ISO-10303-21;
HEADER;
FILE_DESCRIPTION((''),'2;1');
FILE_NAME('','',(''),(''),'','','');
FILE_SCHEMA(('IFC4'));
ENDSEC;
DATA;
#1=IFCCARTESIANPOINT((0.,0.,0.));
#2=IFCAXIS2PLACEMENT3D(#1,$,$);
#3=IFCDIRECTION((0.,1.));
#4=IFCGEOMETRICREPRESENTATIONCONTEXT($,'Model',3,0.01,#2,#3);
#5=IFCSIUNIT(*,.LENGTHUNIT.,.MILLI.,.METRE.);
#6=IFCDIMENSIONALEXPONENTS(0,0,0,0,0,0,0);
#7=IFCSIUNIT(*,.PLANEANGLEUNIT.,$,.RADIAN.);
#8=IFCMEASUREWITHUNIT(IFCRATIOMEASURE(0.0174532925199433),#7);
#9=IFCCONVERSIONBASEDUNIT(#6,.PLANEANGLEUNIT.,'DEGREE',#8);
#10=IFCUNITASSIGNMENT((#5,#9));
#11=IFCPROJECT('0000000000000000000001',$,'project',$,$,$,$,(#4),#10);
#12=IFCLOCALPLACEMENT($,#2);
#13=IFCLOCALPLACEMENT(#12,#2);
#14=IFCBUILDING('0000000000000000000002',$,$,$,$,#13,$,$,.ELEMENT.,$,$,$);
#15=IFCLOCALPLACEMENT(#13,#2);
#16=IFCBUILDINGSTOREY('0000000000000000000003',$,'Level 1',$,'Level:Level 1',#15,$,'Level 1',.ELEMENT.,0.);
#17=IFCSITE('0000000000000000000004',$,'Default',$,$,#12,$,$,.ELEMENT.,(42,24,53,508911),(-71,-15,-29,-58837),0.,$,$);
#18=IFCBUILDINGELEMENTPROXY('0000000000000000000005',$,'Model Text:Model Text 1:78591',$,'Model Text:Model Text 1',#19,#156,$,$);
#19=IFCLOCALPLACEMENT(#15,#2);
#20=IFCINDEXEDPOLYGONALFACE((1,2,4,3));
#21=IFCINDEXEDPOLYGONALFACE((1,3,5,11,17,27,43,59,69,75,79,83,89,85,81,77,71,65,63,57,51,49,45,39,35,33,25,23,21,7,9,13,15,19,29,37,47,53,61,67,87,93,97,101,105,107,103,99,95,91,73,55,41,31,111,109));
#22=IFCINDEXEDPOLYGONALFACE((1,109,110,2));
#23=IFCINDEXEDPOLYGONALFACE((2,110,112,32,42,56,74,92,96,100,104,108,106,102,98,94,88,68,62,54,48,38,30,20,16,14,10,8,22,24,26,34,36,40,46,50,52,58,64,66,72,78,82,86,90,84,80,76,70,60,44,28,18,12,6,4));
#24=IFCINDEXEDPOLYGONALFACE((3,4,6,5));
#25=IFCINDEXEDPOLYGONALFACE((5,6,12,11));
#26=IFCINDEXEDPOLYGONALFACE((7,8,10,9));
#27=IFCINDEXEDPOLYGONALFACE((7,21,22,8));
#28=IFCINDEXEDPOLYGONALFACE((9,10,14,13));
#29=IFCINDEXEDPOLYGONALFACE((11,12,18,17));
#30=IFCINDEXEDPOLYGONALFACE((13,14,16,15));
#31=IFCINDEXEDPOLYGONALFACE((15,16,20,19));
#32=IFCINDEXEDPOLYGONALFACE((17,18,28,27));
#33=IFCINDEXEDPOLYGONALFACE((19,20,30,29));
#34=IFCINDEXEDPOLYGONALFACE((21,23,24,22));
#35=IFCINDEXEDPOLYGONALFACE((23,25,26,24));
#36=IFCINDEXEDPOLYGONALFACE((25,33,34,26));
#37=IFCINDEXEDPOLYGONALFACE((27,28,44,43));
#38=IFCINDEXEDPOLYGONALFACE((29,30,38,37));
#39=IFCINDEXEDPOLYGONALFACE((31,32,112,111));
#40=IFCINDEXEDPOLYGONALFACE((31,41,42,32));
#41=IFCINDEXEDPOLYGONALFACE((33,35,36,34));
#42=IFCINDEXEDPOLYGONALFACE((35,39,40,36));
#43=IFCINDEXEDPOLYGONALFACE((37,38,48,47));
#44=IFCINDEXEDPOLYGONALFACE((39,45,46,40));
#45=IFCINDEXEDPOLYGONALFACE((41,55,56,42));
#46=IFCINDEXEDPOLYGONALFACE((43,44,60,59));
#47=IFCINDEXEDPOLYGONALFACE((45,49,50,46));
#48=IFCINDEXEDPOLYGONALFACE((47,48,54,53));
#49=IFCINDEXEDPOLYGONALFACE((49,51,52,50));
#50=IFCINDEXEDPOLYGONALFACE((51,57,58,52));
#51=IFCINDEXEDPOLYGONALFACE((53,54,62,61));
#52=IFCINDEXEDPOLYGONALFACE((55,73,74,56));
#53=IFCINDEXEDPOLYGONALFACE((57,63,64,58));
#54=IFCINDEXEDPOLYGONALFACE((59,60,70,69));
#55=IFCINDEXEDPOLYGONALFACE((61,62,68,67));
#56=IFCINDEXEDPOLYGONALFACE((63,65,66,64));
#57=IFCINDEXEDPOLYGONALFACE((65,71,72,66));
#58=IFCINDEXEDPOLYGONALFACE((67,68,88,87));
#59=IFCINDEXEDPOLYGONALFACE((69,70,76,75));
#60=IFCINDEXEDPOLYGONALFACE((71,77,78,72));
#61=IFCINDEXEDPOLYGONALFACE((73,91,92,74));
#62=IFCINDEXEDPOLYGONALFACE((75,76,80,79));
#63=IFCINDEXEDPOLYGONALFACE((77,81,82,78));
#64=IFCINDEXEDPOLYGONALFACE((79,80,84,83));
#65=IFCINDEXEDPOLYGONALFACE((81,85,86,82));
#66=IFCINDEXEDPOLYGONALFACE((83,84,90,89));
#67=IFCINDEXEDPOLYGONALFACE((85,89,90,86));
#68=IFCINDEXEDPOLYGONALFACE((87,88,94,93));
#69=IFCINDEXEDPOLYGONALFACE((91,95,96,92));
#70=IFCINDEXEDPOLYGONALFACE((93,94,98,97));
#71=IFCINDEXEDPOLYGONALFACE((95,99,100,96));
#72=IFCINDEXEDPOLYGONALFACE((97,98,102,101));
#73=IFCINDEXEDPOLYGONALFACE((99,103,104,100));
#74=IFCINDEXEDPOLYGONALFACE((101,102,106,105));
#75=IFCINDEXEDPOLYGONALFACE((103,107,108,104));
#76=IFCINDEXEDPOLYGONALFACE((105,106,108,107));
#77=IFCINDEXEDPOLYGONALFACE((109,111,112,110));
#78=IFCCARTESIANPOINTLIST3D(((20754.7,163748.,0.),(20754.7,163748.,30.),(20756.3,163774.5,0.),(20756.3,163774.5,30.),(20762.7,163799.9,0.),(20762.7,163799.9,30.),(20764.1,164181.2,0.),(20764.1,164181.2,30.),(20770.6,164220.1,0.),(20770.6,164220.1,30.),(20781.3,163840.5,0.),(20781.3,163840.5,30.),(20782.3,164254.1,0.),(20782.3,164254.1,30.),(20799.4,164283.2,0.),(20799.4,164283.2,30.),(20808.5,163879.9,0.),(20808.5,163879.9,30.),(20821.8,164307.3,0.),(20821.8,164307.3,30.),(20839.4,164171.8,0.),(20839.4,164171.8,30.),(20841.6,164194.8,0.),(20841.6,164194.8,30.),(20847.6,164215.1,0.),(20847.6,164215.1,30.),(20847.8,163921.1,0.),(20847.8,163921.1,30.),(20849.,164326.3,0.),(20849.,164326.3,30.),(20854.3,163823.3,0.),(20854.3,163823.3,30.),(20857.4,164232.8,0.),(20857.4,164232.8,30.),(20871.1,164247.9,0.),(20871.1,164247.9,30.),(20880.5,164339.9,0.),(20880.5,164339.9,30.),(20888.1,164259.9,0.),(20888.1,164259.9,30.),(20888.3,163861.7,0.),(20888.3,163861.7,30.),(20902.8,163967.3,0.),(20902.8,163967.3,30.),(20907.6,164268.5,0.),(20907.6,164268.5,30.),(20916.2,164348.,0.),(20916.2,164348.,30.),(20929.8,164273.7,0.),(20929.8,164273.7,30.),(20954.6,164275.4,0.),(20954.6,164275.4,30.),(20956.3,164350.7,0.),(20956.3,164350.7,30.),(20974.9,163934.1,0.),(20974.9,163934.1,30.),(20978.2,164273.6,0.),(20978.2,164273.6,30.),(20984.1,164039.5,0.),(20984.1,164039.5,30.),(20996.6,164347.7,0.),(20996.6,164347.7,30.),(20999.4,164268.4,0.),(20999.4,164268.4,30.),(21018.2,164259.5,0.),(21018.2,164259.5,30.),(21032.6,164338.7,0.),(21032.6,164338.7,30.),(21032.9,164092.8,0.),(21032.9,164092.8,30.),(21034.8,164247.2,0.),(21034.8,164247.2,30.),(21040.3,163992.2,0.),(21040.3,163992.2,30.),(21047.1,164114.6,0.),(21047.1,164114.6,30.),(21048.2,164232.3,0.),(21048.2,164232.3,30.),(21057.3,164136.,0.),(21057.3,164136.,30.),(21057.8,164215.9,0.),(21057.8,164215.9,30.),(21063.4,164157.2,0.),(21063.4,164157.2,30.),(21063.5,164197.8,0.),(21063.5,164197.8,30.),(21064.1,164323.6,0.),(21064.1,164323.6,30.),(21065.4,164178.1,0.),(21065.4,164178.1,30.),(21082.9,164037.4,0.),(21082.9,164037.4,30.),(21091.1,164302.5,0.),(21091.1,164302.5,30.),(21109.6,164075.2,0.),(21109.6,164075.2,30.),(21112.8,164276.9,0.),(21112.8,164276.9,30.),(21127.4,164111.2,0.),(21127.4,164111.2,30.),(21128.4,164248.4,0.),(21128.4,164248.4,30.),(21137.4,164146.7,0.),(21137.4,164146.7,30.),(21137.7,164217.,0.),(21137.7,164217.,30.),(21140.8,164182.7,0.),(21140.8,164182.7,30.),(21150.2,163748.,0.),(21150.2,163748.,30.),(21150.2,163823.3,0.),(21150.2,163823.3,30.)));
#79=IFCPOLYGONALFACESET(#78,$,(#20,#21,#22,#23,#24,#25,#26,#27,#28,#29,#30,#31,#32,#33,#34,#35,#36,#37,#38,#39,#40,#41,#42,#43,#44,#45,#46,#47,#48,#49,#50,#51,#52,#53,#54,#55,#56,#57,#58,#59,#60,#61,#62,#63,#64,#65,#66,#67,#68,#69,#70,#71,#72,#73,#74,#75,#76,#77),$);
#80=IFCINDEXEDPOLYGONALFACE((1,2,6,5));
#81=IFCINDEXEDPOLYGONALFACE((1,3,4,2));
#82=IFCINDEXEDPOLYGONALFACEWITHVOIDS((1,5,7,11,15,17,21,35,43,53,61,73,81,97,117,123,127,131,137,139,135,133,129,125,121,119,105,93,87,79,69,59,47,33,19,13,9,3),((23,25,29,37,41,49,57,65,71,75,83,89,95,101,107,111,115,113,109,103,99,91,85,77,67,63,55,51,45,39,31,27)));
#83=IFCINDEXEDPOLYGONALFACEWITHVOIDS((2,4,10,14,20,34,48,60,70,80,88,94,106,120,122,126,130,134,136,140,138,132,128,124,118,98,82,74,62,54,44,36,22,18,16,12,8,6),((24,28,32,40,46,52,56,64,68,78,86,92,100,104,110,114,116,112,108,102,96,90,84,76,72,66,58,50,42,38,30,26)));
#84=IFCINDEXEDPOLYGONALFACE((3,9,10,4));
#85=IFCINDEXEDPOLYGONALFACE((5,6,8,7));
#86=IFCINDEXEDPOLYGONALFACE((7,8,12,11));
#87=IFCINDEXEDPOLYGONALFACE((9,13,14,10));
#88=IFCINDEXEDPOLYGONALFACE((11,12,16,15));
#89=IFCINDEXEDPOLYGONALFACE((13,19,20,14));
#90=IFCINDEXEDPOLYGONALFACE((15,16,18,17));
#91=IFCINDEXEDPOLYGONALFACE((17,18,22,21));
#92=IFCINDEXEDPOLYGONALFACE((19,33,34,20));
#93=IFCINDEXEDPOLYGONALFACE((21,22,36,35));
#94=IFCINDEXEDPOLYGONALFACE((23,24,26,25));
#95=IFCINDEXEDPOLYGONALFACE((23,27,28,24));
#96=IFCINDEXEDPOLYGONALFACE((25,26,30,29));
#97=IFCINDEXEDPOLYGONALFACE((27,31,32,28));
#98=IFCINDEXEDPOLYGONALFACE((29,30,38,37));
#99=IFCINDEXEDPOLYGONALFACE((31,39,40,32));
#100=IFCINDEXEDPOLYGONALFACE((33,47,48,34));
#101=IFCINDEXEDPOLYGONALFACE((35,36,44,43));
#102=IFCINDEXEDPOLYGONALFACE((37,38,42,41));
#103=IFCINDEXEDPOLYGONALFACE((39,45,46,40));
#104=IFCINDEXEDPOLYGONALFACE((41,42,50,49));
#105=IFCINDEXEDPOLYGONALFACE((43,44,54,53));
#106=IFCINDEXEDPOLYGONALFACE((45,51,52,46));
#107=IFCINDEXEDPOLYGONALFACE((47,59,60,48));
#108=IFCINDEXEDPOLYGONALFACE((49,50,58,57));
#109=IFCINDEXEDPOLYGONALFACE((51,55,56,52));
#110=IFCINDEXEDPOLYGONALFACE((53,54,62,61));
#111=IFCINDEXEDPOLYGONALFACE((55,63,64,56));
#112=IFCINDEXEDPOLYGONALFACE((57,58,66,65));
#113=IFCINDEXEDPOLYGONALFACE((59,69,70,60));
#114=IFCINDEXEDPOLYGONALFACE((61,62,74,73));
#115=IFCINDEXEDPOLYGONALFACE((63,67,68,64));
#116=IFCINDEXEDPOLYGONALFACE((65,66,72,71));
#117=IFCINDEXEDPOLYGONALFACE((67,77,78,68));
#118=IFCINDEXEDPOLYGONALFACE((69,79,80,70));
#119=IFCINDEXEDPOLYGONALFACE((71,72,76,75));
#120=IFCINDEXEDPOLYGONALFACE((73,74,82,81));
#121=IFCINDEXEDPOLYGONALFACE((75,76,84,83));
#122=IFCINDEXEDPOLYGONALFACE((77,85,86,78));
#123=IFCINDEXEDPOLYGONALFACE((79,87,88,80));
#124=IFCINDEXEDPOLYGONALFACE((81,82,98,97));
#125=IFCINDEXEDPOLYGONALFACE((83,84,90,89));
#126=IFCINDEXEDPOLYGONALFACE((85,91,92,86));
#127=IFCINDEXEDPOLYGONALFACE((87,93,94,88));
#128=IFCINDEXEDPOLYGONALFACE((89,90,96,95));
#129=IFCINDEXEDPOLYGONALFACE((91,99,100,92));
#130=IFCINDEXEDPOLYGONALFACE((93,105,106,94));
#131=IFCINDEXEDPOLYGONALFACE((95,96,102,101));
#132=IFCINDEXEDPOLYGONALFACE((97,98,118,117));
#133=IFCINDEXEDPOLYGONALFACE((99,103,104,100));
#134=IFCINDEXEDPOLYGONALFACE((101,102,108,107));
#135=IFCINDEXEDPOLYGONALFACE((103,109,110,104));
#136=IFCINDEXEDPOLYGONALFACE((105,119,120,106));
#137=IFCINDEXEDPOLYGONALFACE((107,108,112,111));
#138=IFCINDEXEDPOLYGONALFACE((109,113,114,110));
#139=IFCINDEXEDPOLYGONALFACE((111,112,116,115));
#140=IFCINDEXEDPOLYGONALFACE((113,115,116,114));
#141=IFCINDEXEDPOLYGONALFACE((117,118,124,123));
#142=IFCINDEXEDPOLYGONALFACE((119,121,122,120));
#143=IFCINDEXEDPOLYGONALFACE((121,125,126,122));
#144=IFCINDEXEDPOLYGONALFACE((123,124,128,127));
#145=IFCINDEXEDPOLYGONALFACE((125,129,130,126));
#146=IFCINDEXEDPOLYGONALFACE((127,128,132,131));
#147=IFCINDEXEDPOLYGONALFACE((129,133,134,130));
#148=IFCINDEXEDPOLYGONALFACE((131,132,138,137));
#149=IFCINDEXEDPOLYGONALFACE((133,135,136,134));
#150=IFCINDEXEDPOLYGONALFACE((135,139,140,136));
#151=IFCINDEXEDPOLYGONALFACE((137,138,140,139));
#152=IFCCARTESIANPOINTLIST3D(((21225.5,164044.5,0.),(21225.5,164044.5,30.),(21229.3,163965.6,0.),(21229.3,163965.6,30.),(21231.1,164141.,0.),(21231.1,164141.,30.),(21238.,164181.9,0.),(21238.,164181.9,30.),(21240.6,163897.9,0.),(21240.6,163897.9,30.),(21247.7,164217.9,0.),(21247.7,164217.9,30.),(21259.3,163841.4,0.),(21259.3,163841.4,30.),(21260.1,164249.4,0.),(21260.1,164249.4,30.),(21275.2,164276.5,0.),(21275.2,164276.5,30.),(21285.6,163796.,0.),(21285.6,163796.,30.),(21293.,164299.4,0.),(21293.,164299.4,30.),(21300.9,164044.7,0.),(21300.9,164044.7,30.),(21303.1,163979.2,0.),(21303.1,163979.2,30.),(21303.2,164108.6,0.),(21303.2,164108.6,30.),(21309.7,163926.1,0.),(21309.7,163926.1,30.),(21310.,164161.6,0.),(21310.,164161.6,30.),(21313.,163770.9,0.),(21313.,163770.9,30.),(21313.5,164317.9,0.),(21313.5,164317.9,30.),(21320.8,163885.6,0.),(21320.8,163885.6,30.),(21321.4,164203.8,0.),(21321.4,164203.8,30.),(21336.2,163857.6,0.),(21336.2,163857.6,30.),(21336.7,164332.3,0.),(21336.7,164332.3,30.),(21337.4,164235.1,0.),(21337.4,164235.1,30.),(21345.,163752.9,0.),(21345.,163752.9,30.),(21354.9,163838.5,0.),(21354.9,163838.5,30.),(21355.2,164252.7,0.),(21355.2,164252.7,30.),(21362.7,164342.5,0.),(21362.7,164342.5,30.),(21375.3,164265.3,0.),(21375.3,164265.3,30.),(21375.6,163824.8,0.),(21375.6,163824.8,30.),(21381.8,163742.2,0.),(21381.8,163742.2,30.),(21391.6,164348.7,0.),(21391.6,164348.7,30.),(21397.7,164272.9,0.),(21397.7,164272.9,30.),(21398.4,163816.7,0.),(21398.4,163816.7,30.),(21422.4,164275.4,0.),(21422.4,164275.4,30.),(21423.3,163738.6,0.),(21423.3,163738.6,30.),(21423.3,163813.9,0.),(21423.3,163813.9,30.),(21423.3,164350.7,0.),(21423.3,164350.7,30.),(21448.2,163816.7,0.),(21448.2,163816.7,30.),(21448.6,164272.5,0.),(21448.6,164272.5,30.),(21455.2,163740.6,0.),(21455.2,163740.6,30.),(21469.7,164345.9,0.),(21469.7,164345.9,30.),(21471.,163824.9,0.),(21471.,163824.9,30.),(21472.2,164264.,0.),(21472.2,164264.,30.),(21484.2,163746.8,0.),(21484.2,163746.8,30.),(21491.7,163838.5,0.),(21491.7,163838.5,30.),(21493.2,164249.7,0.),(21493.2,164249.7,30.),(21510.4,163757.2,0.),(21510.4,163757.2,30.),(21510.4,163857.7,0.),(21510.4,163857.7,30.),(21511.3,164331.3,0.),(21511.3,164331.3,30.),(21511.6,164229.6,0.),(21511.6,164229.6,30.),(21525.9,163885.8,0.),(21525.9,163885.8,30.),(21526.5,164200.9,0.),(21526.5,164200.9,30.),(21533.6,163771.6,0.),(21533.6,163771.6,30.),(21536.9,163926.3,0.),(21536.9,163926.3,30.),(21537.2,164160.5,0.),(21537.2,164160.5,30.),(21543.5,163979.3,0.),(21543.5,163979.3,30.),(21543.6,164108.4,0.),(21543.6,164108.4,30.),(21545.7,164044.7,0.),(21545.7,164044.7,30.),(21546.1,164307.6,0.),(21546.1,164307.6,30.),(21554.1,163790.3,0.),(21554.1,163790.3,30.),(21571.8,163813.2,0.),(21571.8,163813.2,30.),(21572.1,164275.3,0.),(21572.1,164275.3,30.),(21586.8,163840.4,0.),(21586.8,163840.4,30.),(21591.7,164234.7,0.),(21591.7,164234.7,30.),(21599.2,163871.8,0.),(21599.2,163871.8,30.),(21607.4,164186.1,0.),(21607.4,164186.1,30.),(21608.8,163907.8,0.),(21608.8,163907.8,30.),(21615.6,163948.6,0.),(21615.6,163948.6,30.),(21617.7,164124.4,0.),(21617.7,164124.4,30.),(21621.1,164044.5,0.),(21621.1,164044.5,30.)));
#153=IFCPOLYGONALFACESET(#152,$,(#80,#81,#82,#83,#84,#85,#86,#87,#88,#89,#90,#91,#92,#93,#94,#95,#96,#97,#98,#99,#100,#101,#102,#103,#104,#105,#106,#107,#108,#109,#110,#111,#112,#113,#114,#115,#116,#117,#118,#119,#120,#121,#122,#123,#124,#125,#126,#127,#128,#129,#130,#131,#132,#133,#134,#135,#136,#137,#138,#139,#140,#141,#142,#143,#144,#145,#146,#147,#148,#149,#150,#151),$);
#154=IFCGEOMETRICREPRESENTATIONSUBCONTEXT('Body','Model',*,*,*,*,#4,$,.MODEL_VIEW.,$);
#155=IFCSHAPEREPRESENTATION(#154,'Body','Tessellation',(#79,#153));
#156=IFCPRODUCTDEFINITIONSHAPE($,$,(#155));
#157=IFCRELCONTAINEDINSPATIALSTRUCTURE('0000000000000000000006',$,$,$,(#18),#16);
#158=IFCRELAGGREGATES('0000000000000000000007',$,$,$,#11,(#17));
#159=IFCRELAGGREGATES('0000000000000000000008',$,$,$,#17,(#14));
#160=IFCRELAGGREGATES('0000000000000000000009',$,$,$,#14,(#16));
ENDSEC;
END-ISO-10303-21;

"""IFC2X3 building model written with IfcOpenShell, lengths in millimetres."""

from ifc_helpers import new_model, entity, si_unit, converted_unit, direction, frame, origin, place, context, subcontext, project, spatial, polyline, outline, extrude, element, save


model = new_model("IFC2X3")

# Units and contexts
model_context = context("Model", 3, precision=0.01, world=origin(), true_north=direction((0.0, 1.0)))
body_context = subcontext(model_context, "Body", "Model", "MODEL_VIEW")
ifc_project = project(units=[si_unit("LENGTHUNIT", "METRE", prefix="MILLI"), converted_unit("PLANEANGLEUNIT", "DEGREE", entity("IfcRatioMeasure", 0.0174532925199433), si_unit("PLANEANGLEUNIT", "RADIAN"), dimensions=[0, 0, 0, 0, 0, 0, 0])], contexts=[model_context])

# Site, building, storey
site_placement = place(None, origin())
site = spatial("IfcSite", under=ifc_project, at=site_placement, Name="Default", CompositionType="ELEMENT", RefLatitude=(42, 24, 53, 508911), RefLongitude=(-71, -15, -29, -58837), RefElevation=0.0)
building_placement = place(site_placement, origin())
building = spatial("IfcBuilding", under=site, at=building_placement, CompositionType="ELEMENT")
storey_placement = place(building_placement, origin())
storey = spatial("IfcBuildingStorey", under=building, at=storey_placement, Name="Level 1", ObjectType="Level:Level 1", LongName="Level 1", CompositionType="ELEMENT", Elevation=0.0)

# Building element proxy
proxy_1_placement = place(storey_placement, origin())
element("IfcBuildingElementProxy", 1, at=proxy_1_placement, inside=storey, Name="Model Text:Model Text 1:78591", ObjectType="Model Text:Model Text 1", context=body_context, shape_type="SweptSolid", body=[
    extrude(outline(polyline([(-190.2, -317.5), (-190.2, -392.8), (205.4, -392.8), (203.7, -366.3), (197.3, -340.9), (178.7, -300.3), (151.5, -260.9), (112.2, -219.7), (57.2, -173.6), (-24.1, -101.3), (-72.9, -48.0), (-87.1, -26.3), (-97.3, -4.8), (-103.4, 16.4), (-105.4, 37.3), (-103.5, 57.0), (-97.7, 75.0), (-88.2, 91.5), (-74.7, 106.4), (-58.2, 118.7), (-39.4, 127.5), (-18.2, 132.8), (5.4, 134.6), (30.2, 132.9), (52.4, 127.7), (72.0, 119.1), (88.9, 107.1), (102.6, 92.0), (112.5, 74.3), (118.5, 54.0), (120.6, 31.0), (196.0, 40.4), (189.5, 79.3), (177.7, 113.3), (160.6, 142.4), (138.2, 166.5), (111.0, 185.5), (79.5, 199.1), (43.8, 207.2), (3.8, 209.9), (-36.6, 206.9), (-72.5, 197.9), (-104.0, 182.8), (-131.1, 161.7), (-152.8, 136.1), (-168.3, 107.6), (-177.6, 76.2), (-180.8, 41.9), (-177.4, 5.8), (-167.4, -29.6), (-149.5, -65.6), (-122.8, -103.4), (-80.3, -148.6), (-14.9, -206.7), (71.8, -279.1), (105.8, -317.5), (-190.2, -317.5)])), frame((20960.0, 164140.8, 0.0), z_axis=(0.0, 0.0, -1.0), x_axis=(-1.0, 0.0, 0.0)), (0.0, 0.0, -1.0), 30.0),
    extrude(outline(polyline([(-10.6, -198.7), (68.3, -198.7), (136.5, -190.7), (193.9, -174.7), (240.5, -150.6), (266.9, -124.4), (286.3, -93.2), (298.8, -57.0), (304.3, -15.7), (303.8, 16.2), (299.0, 45.5), (289.9, 72.1), (276.6, 96.0), (258.9, 117.3), (236.9, 136.2), (210.4, 152.5), (179.6, 166.3), (144.1, 177.6), (103.7, 186.3), (8.2, 196.4), (-71.8, 196.7), (-134.0, 189.4), (-183.3, 176.1), (-224.7, 158.4), (-258.2, 133.9), (-283.5, 100.3), (-300.1, 59.5), (-307.1, 13.4), (-306.6, -18.4), (-301.8, -47.5), (-292.8, -74.0), (-279.6, -97.9), (-262.0, -119.2), (-240.0, -138.1), (-213.6, -154.5), (-182.8, -168.4), (-147.3, -179.8), (-106.7, -188.6), (-10.6, -198.7)]), holes=[polyline([(-7.2, -123.5), (-71.0, -118.2), (-123.6, -108.8), (-165.2, -95.4), (-195.7, -78.0), (-212.4, -59.4), (-224.1, -38.7), (-230.6, -15.9), (-231.9, 8.9), (-227.8, 35.0), (-218.1, 58.1), (-202.8, 78.4), (-182.0, 95.8), (-152.6, 109.4), (-111.7, 118.1), (-59.4, 122.0), (4.4, 121.1), (69.6, 115.8), (122.2, 106.7), (162.2, 93.7), (189.5, 77.0), (207.7, 57.4), (220.4, 36.0), (227.5, 12.8), (229.1, -12.1), (225.2, -36.8), (215.9, -59.2), (201.3, -79.3), (181.4, -97.1), (152.6, -111.2), (111.6, -120.3), (58.3, -124.4), (-7.2, -123.5)])]), frame((21424.6, 164043.3, 0.0), z_axis=(0.0, 0.0, 1.0), x_axis=(0.047515, -0.998871, 0.0)), (0.0, 0.0, 1.0), 30.0),
])

save(model, "model.ifc")
